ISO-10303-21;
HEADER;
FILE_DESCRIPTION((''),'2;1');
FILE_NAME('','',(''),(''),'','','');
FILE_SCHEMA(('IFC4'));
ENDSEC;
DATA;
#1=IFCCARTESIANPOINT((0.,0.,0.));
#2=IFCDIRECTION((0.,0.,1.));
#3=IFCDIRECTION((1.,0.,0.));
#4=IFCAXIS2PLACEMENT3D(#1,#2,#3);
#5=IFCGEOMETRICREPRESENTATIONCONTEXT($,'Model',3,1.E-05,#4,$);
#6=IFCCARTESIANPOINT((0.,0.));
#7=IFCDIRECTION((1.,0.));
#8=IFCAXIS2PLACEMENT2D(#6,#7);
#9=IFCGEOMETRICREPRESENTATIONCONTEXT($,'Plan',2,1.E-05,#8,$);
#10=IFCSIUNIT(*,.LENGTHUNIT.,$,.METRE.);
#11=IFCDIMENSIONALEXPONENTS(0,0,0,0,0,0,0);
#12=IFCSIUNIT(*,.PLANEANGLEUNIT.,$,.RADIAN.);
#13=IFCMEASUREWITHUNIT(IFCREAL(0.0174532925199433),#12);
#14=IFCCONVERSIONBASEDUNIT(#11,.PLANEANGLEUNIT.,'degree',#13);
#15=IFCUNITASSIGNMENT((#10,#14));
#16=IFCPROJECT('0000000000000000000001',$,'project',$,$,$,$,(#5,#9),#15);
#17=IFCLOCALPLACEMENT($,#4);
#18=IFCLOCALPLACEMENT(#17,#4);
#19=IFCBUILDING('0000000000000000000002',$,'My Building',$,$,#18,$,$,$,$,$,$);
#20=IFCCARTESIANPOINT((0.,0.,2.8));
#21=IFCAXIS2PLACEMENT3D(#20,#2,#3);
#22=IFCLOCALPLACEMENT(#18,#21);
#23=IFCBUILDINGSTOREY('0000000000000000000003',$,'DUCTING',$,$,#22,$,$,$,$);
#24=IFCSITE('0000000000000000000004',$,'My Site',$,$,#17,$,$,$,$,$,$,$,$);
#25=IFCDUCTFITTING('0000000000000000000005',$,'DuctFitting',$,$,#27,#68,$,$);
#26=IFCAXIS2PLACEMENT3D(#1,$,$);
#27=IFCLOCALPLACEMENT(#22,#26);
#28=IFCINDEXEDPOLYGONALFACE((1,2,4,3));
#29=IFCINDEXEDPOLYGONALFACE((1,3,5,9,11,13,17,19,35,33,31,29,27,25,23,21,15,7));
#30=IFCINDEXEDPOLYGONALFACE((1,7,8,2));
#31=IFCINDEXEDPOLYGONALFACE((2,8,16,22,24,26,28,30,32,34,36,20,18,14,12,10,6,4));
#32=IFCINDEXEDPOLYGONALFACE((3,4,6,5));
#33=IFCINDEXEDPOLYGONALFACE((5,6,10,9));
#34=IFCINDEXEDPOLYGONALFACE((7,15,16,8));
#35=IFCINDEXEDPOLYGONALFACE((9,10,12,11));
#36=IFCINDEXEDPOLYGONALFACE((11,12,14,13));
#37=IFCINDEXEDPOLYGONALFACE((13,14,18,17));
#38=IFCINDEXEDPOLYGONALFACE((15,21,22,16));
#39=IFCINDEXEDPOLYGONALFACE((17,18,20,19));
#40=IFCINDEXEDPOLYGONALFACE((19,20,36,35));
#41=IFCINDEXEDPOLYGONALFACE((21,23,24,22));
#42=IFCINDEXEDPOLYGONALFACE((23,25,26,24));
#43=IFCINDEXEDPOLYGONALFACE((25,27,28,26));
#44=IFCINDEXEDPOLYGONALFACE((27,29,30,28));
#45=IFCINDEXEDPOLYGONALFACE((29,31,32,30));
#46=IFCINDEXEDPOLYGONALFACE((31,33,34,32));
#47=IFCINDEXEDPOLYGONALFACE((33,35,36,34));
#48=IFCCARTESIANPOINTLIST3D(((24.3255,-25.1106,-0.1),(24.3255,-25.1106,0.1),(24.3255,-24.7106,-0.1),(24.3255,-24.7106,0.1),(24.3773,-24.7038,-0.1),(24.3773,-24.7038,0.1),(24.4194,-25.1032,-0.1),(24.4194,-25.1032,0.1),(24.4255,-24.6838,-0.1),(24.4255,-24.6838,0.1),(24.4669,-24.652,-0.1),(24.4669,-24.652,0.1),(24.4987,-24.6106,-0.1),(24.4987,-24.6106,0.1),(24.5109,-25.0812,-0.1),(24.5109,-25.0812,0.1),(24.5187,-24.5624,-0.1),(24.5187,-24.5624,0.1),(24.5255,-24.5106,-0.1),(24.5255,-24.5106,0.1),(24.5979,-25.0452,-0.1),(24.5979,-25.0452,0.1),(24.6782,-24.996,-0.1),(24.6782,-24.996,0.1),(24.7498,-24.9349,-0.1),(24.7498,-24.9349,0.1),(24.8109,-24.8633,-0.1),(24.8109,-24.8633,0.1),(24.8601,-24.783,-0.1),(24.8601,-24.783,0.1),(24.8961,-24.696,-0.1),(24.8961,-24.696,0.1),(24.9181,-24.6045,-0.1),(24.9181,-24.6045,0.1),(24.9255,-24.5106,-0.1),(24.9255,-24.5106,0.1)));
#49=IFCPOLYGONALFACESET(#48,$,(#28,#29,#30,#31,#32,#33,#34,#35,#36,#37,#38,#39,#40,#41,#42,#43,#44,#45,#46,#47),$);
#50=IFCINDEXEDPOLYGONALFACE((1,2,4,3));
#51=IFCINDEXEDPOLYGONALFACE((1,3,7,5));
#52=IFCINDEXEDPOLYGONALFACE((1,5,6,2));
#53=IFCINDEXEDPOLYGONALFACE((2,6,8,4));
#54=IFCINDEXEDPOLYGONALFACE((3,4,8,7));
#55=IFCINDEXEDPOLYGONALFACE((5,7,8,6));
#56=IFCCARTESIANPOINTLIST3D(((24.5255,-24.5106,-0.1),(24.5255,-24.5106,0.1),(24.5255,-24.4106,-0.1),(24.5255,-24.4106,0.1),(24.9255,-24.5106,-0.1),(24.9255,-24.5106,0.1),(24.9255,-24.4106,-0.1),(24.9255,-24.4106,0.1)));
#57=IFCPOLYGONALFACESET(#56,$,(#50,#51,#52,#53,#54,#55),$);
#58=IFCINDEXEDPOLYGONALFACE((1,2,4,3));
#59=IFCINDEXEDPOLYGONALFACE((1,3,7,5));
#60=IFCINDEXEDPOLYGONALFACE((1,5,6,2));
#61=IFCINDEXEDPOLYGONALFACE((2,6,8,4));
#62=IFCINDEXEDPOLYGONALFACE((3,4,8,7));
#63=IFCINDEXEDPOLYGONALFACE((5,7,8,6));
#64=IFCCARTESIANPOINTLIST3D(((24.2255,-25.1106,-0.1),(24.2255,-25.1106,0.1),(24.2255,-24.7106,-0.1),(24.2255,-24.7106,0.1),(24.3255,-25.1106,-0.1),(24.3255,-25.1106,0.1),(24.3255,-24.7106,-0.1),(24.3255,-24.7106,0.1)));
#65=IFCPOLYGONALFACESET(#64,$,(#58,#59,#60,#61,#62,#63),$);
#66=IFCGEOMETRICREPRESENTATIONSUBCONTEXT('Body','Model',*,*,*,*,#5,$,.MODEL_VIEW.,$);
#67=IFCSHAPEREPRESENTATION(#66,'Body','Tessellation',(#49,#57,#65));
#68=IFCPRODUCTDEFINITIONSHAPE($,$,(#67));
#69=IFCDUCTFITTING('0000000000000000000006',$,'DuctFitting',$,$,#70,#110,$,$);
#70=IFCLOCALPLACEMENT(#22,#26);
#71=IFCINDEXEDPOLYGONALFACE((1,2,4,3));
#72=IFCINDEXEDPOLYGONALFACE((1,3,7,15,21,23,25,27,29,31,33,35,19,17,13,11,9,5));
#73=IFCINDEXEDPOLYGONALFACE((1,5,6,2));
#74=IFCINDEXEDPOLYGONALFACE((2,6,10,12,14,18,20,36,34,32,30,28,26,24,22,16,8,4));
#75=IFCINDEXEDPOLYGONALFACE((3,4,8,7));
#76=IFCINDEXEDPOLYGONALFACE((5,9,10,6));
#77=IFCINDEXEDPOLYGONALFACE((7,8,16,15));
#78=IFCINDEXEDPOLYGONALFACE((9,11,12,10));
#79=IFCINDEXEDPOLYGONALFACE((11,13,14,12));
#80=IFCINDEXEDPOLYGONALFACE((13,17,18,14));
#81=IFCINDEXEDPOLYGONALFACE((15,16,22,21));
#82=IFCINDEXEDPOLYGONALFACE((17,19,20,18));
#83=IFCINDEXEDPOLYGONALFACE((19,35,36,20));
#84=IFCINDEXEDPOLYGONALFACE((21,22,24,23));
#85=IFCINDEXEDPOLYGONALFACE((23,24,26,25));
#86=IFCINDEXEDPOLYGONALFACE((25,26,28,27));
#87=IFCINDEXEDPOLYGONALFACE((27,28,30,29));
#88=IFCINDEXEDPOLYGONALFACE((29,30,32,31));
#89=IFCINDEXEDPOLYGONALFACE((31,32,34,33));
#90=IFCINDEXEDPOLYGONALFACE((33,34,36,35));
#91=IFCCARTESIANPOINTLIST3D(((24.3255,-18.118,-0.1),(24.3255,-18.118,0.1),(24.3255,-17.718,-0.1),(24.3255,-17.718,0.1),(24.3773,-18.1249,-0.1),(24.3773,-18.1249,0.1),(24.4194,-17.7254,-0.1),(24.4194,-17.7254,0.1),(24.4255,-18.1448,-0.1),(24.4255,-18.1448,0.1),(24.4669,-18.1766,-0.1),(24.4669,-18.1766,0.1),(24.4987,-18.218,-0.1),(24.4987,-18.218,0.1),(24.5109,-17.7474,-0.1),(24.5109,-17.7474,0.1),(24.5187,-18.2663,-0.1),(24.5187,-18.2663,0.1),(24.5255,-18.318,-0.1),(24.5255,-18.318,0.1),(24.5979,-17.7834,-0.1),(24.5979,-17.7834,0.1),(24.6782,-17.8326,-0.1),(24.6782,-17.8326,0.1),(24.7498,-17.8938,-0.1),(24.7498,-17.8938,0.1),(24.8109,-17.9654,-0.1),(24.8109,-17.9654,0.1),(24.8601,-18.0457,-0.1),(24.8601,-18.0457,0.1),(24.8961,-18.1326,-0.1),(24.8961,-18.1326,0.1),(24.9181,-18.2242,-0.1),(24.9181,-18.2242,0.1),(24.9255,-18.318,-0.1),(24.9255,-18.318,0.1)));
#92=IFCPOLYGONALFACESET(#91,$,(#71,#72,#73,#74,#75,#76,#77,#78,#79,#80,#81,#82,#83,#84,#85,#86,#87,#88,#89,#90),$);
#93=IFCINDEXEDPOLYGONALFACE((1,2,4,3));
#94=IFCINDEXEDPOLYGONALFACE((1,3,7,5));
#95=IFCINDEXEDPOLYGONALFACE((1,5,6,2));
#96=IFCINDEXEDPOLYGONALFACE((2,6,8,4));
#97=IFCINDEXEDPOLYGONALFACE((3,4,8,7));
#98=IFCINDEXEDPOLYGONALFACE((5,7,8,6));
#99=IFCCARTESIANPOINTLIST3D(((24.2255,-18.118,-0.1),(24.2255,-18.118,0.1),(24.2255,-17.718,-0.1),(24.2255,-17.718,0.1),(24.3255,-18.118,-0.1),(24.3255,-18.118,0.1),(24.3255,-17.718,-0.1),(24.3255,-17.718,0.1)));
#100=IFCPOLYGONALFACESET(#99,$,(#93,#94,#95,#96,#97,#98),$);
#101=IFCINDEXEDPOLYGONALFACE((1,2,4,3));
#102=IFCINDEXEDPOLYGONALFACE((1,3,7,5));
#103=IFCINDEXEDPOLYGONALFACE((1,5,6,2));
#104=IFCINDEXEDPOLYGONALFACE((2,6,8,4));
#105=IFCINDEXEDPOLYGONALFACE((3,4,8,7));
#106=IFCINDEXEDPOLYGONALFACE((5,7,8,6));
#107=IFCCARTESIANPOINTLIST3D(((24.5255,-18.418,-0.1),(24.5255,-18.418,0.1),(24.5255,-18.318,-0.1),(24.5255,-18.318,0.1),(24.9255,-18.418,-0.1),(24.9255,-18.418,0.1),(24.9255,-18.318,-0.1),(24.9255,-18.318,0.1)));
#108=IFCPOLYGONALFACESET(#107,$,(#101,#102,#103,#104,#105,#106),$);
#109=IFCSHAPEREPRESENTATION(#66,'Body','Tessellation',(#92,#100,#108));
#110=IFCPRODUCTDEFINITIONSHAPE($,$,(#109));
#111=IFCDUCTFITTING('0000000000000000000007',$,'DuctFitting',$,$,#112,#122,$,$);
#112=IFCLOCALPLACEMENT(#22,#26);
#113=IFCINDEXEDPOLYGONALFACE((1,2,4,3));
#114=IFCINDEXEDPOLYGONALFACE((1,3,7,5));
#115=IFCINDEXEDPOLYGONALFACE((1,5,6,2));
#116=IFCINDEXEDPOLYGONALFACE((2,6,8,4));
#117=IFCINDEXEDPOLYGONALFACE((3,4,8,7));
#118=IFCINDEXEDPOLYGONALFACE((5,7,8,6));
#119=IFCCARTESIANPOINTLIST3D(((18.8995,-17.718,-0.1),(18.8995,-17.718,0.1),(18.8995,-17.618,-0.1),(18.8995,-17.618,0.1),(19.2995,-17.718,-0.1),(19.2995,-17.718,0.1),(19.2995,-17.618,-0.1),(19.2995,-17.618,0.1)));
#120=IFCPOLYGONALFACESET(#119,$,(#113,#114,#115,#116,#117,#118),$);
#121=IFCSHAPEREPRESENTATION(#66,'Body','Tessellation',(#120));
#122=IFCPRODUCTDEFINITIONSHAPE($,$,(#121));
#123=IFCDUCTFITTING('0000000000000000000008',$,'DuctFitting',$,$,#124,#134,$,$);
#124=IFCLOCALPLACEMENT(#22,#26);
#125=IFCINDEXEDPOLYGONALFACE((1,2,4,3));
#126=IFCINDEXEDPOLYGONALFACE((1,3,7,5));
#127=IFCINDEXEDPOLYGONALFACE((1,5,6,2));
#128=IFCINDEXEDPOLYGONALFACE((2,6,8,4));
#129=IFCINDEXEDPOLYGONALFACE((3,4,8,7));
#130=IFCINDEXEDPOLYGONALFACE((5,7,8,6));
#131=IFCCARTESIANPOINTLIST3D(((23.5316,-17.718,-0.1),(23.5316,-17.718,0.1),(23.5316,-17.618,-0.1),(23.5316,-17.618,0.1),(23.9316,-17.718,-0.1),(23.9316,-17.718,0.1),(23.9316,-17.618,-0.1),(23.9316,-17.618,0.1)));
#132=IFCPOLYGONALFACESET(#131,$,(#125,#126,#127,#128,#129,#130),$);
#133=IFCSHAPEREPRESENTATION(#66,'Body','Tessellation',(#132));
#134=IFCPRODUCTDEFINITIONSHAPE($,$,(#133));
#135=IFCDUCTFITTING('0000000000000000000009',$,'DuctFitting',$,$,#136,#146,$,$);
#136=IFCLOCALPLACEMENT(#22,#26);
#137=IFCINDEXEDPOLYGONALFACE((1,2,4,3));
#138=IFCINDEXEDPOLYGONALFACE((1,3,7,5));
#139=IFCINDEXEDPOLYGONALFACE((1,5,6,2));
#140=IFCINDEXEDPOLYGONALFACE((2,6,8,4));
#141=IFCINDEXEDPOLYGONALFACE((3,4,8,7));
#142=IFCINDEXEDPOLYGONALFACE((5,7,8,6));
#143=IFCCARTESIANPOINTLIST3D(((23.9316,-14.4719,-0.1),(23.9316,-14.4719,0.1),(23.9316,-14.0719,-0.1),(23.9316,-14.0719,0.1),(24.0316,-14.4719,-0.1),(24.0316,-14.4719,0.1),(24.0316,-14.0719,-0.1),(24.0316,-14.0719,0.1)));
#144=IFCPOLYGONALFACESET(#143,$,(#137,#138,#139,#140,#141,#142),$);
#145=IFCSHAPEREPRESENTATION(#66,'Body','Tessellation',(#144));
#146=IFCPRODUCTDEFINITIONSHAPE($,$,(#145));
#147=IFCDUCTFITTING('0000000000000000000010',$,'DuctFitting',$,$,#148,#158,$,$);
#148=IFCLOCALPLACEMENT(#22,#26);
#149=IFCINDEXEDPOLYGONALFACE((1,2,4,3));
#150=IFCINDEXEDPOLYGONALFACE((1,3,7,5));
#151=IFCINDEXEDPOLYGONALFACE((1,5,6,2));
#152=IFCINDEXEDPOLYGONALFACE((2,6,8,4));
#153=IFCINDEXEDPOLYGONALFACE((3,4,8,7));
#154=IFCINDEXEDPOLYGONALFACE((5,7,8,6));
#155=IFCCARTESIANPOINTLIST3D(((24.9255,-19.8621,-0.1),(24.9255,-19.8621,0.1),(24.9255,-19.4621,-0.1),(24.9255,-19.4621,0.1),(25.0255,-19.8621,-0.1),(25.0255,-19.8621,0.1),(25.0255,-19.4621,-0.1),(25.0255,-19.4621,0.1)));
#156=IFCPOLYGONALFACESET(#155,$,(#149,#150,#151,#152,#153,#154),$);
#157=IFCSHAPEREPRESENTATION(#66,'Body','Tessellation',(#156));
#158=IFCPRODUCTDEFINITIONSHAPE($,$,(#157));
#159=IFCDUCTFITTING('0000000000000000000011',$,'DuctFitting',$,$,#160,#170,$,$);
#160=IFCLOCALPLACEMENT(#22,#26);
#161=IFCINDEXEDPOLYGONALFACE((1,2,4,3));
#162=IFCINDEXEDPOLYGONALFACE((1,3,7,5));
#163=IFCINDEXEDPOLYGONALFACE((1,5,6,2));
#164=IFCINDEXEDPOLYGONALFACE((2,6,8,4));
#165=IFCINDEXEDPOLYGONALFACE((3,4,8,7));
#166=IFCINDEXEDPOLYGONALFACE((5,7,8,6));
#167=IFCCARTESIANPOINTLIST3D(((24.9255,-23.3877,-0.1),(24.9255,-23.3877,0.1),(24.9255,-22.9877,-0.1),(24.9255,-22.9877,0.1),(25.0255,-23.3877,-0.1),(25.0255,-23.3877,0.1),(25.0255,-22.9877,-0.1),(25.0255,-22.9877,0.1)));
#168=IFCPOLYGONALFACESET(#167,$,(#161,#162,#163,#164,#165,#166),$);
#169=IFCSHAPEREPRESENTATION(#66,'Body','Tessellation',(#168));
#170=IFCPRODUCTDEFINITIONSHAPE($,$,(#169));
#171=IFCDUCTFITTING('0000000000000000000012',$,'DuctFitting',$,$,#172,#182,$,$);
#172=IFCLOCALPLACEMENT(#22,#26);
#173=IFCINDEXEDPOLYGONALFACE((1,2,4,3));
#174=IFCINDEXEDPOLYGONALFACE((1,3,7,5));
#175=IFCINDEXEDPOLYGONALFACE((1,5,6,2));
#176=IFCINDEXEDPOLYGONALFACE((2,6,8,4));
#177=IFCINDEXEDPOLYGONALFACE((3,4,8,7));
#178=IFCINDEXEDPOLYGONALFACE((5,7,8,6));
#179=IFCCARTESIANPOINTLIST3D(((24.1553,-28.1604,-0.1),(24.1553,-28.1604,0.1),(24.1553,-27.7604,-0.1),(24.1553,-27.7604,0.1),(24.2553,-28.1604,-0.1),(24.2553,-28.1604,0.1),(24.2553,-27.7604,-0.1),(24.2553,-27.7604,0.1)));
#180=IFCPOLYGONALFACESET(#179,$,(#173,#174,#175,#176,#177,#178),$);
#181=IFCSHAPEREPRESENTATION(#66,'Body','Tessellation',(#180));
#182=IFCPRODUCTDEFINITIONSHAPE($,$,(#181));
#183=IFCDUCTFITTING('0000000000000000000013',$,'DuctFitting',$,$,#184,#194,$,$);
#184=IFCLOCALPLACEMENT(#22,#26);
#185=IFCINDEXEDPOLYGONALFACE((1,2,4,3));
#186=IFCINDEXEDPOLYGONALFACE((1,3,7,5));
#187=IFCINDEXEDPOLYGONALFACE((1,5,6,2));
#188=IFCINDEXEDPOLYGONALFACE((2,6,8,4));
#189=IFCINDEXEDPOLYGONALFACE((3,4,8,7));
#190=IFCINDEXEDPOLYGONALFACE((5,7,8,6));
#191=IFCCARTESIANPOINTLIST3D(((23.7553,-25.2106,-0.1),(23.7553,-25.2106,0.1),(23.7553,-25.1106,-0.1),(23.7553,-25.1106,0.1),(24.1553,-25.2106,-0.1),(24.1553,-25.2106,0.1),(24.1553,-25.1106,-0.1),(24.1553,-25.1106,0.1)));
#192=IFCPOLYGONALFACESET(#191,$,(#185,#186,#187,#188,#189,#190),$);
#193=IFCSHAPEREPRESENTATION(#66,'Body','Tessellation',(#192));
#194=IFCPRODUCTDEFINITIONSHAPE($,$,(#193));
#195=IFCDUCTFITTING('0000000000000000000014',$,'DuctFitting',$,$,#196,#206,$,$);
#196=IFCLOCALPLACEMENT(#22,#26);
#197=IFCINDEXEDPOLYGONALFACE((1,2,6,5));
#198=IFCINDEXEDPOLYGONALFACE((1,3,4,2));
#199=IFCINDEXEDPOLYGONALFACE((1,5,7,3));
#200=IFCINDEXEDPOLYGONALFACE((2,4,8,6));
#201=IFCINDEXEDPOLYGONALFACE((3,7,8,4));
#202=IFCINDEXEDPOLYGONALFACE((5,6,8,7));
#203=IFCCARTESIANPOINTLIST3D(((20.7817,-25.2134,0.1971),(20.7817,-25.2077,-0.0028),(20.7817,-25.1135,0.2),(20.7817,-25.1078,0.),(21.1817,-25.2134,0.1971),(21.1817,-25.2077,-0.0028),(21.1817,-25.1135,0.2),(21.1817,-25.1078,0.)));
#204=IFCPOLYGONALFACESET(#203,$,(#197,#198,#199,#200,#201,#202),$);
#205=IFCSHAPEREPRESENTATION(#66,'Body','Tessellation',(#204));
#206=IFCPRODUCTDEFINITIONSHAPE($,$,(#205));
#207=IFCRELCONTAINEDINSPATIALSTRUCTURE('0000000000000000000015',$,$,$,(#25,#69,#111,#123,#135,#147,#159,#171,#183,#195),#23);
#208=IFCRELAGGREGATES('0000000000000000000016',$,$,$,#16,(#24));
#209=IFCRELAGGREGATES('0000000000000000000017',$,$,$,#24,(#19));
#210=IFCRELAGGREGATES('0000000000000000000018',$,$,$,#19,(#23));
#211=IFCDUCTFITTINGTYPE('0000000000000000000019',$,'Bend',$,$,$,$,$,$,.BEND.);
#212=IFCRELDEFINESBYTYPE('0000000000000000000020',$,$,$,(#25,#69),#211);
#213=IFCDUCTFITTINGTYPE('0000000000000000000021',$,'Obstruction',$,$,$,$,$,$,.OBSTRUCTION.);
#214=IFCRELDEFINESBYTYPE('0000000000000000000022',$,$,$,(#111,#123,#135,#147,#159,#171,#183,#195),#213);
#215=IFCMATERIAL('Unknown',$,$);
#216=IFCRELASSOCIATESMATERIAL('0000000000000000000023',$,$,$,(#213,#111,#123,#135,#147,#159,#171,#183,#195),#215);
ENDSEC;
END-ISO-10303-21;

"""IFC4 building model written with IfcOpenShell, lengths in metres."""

from ifc_helpers import new_model, entity, si_unit, converted_unit, frame, origin_with_axes, origin_2d_with_axis, place, context, subcontext, project, spatial, line, arc, indexed_curve, rectangle, outline, extrude, source, transform, mapped, material, material_profile, profile_set, profile_usage, type_object, type_shapes, element, save


model = new_model("IFC4")

# Units and contexts
model_context = context("Model", 3, precision=1e-05, world=origin_with_axes())
plan_context = context("Plan", 2, precision=1e-05, world=origin_2d_with_axis())
body_context = subcontext(model_context, "Body", "Model", "MODEL_VIEW")
ifc_project = project(units=[si_unit("LENGTHUNIT", "METRE"), converted_unit("PLANEANGLEUNIT", "degree", entity("IfcReal", 0.0174532925199433), si_unit("PLANEANGLEUNIT", "RADIAN"), dimensions=[0, 0, 0, 0, 0, 0, 0])], contexts=[model_context, plan_context])

# Site, building, storey
site_placement = place(None, origin_with_axes())
site = spatial("IfcSite", under=ifc_project, at=site_placement, Name="My Site")
building_placement = place(site_placement, origin_with_axes())
building = spatial("IfcBuilding", under=site, at=building_placement, Name="My Building")
storey_placement = place(building_placement, frame((0.0, 0.0, 2.8), z_axis=(0.0, 0.0, 1.0), x_axis=(1.0, 0.0, 0.0)))
storey = spatial("IfcBuildingStorey", under=building, at=storey_placement, Name="DUCTING")

# Shared definitions
ifc_material = material(Name="Unknown")

# Duct fittings
duct_fitting_type_1 = type_object("IfcDuctFittingType", Name="Bend", PredefinedType="BEND")
shared_shape = source(origin_with_axes(), body_context, "Body", "SweptSolid", [
    extrude(outline(indexed_curve([(-0.2, 0.0), (-0.2586, -0.1414), (-0.4, -0.2), (-0.4, -0.6), (0.0243, -0.4243), (0.2, 0.0)], segments=[arc(1, 2, 3), line(3, 4), arc(4, 5, 6), line(6, 1)])), frame((0.0, -0.1, -0.1), z_axis=(0.0, -1.0, 0.0), x_axis=(1.0, 0.0, 0.0)), (0.0, 0.0, -1.0), 0.2),
    extrude(rectangle(XDim=0.4, YDim=0.2), origin_with_axes(), (0.0, 0.0, -1.0), 0.1),
    extrude(rectangle(XDim=0.4, YDim=0.2), frame((-0.4, 0.0, -0.5), z_axis=(-1.0, 0.0, 0.0), x_axis=(0.0, 0.0, -1.0)), (0.0, 0.0, 1.0), 0.1),
])
type_shapes(duct_fitting_type_1, [shared_shape])
for number, where, z_axis, x_axis, name in (
    (1, (24.7255, -24.4106, 0.0), (0.0, 1.0, 0.0), (1.0, 0.0, 0.0), "DuctFitting"),
    (2, (24.2255, -17.918, 0.0), (-1.0, 0.0, 0.0), (0.0, 1.0, 0.0), "DuctFitting"),
):
    element("IfcDuctFitting", number, at=place(storey_placement, frame(where, z_axis=z_axis, x_axis=x_axis)), inside=storey, type_object=duct_fitting_type_1, Name=name, context=body_context, shape_type="MappedRepresentation", body=[
        mapped(shared_shape, transform((0.0, 0.0, 0.0), x_axis=(1.0, 0.0, 0.0), y_axis=(0.0, 1.0, 0.0), z_axis=(0.0, 0.0, 1.0), scale=1.0)),
    ])
ifc_material_profile_1 = material_profile(ifc_material, rectangle(XDim=0.4, YDim=0.2))
ifc_profile_set_1 = profile_set([ifc_material_profile_1])
ifc_profile_usage_1 = profile_usage(ifc_profile_set_1, cardinal=5)
duct_fitting_type_2 = type_object("IfcDuctFittingType", Name="Obstruction", PredefinedType="OBSTRUCTION", material=ifc_profile_set_1)
duct_fitting_1_placement = place(storey_placement, frame((19.0995, -17.718, 0.0), z_axis=(0.0, 1.0, 0.0), x_axis=(-1.0, 0.0, 0.0)))
element("IfcDuctFitting", 3, at=duct_fitting_1_placement, inside=storey, type_object=duct_fitting_type_2, material=ifc_profile_usage_1, Name="DuctFitting", context=body_context, shape_type="SweptSolid", body=[
    extrude(rectangle(XDim=0.4, YDim=0.2), origin_with_axes(), (0.0, 0.0, 1.0), 0.1),
])
ifc_profile_usage_2 = profile_usage(ifc_profile_set_1, cardinal=5)
duct_fitting_2_placement = place(storey_placement, frame((23.7316, -17.718, 0.0), z_axis=(0.0, 1.0, 0.0), x_axis=(-1.0, 0.0, 0.0)))
element("IfcDuctFitting", 4, at=duct_fitting_2_placement, inside=storey, type_object=duct_fitting_type_2, material=ifc_profile_usage_2, Name="DuctFitting", context=body_context, shape_type="SweptSolid", body=[
    extrude(rectangle(XDim=0.4, YDim=0.2), origin_with_axes(), (0.0, 0.0, 1.0), 0.1),
])
ifc_profile_usage_3 = profile_usage(ifc_profile_set_1, cardinal=5)
duct_fitting_3_placement = place(storey_placement, frame((23.9316, -14.2719, 0.0), z_axis=(1.0, 0.0, 0.0), x_axis=(0.0, 1.0, 0.0)))
element("IfcDuctFitting", 5, at=duct_fitting_3_placement, inside=storey, type_object=duct_fitting_type_2, material=ifc_profile_usage_3, Name="DuctFitting", context=body_context, shape_type="SweptSolid", body=[
    extrude(rectangle(XDim=0.4, YDim=0.2), origin_with_axes(), (0.0, 0.0, 1.0), 0.1),
])
ifc_profile_usage_4 = profile_usage(ifc_profile_set_1, cardinal=5)
duct_fitting_4_placement = place(storey_placement, frame((24.9255, -19.6621, 0.0), z_axis=(1.0, 0.0, 0.0), x_axis=(0.0, 1.0, 0.0)))
element("IfcDuctFitting", 6, at=duct_fitting_4_placement, inside=storey, type_object=duct_fitting_type_2, material=ifc_profile_usage_4, Name="DuctFitting", context=body_context, shape_type="SweptSolid", body=[
    extrude(rectangle(XDim=0.4, YDim=0.2), origin_with_axes(), (0.0, 0.0, 1.0), 0.1),
])
ifc_profile_usage_5 = profile_usage(ifc_profile_set_1, cardinal=5)
duct_fitting_5_placement = place(storey_placement, frame((24.9255, -23.1877, 0.0), z_axis=(1.0, 0.0, 0.0), x_axis=(0.0, 1.0, 0.0)))
element("IfcDuctFitting", 7, at=duct_fitting_5_placement, inside=storey, type_object=duct_fitting_type_2, material=ifc_profile_usage_5, Name="DuctFitting", context=body_context, shape_type="SweptSolid", body=[
    extrude(rectangle(XDim=0.4, YDim=0.2), origin_with_axes(), (0.0, 0.0, 1.0), 0.1),
])
ifc_profile_usage_6 = profile_usage(ifc_profile_set_1, cardinal=5)
duct_fitting_6_placement = place(storey_placement, frame((24.1553, -27.9604, 0.0), z_axis=(1.0, 0.0, 0.0), x_axis=(0.0, 1.0, 0.0)))
element("IfcDuctFitting", 8, at=duct_fitting_6_placement, inside=storey, type_object=duct_fitting_type_2, material=ifc_profile_usage_6, Name="DuctFitting", context=body_context, shape_type="SweptSolid", body=[
    extrude(rectangle(XDim=0.4, YDim=0.2), origin_with_axes(), (0.0, 0.0, 1.0), 0.1),
])
ifc_profile_usage_7 = profile_usage(ifc_profile_set_1, cardinal=5)
duct_fitting_7_placement = place(storey_placement, frame((23.9553, -25.1106, 0.0), z_axis=(0.0, -1.0, 0.0), x_axis=(1.0, 0.0, 0.0)))
element("IfcDuctFitting", 9, at=duct_fitting_7_placement, inside=storey, type_object=duct_fitting_type_2, material=ifc_profile_usage_7, Name="DuctFitting", context=body_context, shape_type="SweptSolid", body=[
    extrude(rectangle(XDim=0.4, YDim=0.2), origin_with_axes(), (0.0, 0.0, 1.0), 0.1),
])
ifc_profile_usage_8 = profile_usage(ifc_profile_set_1, cardinal=5)
duct_fitting_8_placement = place(storey_placement, frame((20.9817, -25.1106, 0.1), z_axis=(-0.000001, -0.999595, -0.028447), x_axis=(1.0, -0.000001, 0.0)))
element("IfcDuctFitting", 10, at=duct_fitting_8_placement, inside=storey, type_object=duct_fitting_type_2, material=ifc_profile_usage_8, Name="DuctFitting", context=body_context, shape_type="SweptSolid", body=[
    extrude(rectangle(XDim=0.4, YDim=0.2), origin_with_axes(), (0.0, 0.0, 1.0), 0.1),
])

save(model, "model.ifc")
